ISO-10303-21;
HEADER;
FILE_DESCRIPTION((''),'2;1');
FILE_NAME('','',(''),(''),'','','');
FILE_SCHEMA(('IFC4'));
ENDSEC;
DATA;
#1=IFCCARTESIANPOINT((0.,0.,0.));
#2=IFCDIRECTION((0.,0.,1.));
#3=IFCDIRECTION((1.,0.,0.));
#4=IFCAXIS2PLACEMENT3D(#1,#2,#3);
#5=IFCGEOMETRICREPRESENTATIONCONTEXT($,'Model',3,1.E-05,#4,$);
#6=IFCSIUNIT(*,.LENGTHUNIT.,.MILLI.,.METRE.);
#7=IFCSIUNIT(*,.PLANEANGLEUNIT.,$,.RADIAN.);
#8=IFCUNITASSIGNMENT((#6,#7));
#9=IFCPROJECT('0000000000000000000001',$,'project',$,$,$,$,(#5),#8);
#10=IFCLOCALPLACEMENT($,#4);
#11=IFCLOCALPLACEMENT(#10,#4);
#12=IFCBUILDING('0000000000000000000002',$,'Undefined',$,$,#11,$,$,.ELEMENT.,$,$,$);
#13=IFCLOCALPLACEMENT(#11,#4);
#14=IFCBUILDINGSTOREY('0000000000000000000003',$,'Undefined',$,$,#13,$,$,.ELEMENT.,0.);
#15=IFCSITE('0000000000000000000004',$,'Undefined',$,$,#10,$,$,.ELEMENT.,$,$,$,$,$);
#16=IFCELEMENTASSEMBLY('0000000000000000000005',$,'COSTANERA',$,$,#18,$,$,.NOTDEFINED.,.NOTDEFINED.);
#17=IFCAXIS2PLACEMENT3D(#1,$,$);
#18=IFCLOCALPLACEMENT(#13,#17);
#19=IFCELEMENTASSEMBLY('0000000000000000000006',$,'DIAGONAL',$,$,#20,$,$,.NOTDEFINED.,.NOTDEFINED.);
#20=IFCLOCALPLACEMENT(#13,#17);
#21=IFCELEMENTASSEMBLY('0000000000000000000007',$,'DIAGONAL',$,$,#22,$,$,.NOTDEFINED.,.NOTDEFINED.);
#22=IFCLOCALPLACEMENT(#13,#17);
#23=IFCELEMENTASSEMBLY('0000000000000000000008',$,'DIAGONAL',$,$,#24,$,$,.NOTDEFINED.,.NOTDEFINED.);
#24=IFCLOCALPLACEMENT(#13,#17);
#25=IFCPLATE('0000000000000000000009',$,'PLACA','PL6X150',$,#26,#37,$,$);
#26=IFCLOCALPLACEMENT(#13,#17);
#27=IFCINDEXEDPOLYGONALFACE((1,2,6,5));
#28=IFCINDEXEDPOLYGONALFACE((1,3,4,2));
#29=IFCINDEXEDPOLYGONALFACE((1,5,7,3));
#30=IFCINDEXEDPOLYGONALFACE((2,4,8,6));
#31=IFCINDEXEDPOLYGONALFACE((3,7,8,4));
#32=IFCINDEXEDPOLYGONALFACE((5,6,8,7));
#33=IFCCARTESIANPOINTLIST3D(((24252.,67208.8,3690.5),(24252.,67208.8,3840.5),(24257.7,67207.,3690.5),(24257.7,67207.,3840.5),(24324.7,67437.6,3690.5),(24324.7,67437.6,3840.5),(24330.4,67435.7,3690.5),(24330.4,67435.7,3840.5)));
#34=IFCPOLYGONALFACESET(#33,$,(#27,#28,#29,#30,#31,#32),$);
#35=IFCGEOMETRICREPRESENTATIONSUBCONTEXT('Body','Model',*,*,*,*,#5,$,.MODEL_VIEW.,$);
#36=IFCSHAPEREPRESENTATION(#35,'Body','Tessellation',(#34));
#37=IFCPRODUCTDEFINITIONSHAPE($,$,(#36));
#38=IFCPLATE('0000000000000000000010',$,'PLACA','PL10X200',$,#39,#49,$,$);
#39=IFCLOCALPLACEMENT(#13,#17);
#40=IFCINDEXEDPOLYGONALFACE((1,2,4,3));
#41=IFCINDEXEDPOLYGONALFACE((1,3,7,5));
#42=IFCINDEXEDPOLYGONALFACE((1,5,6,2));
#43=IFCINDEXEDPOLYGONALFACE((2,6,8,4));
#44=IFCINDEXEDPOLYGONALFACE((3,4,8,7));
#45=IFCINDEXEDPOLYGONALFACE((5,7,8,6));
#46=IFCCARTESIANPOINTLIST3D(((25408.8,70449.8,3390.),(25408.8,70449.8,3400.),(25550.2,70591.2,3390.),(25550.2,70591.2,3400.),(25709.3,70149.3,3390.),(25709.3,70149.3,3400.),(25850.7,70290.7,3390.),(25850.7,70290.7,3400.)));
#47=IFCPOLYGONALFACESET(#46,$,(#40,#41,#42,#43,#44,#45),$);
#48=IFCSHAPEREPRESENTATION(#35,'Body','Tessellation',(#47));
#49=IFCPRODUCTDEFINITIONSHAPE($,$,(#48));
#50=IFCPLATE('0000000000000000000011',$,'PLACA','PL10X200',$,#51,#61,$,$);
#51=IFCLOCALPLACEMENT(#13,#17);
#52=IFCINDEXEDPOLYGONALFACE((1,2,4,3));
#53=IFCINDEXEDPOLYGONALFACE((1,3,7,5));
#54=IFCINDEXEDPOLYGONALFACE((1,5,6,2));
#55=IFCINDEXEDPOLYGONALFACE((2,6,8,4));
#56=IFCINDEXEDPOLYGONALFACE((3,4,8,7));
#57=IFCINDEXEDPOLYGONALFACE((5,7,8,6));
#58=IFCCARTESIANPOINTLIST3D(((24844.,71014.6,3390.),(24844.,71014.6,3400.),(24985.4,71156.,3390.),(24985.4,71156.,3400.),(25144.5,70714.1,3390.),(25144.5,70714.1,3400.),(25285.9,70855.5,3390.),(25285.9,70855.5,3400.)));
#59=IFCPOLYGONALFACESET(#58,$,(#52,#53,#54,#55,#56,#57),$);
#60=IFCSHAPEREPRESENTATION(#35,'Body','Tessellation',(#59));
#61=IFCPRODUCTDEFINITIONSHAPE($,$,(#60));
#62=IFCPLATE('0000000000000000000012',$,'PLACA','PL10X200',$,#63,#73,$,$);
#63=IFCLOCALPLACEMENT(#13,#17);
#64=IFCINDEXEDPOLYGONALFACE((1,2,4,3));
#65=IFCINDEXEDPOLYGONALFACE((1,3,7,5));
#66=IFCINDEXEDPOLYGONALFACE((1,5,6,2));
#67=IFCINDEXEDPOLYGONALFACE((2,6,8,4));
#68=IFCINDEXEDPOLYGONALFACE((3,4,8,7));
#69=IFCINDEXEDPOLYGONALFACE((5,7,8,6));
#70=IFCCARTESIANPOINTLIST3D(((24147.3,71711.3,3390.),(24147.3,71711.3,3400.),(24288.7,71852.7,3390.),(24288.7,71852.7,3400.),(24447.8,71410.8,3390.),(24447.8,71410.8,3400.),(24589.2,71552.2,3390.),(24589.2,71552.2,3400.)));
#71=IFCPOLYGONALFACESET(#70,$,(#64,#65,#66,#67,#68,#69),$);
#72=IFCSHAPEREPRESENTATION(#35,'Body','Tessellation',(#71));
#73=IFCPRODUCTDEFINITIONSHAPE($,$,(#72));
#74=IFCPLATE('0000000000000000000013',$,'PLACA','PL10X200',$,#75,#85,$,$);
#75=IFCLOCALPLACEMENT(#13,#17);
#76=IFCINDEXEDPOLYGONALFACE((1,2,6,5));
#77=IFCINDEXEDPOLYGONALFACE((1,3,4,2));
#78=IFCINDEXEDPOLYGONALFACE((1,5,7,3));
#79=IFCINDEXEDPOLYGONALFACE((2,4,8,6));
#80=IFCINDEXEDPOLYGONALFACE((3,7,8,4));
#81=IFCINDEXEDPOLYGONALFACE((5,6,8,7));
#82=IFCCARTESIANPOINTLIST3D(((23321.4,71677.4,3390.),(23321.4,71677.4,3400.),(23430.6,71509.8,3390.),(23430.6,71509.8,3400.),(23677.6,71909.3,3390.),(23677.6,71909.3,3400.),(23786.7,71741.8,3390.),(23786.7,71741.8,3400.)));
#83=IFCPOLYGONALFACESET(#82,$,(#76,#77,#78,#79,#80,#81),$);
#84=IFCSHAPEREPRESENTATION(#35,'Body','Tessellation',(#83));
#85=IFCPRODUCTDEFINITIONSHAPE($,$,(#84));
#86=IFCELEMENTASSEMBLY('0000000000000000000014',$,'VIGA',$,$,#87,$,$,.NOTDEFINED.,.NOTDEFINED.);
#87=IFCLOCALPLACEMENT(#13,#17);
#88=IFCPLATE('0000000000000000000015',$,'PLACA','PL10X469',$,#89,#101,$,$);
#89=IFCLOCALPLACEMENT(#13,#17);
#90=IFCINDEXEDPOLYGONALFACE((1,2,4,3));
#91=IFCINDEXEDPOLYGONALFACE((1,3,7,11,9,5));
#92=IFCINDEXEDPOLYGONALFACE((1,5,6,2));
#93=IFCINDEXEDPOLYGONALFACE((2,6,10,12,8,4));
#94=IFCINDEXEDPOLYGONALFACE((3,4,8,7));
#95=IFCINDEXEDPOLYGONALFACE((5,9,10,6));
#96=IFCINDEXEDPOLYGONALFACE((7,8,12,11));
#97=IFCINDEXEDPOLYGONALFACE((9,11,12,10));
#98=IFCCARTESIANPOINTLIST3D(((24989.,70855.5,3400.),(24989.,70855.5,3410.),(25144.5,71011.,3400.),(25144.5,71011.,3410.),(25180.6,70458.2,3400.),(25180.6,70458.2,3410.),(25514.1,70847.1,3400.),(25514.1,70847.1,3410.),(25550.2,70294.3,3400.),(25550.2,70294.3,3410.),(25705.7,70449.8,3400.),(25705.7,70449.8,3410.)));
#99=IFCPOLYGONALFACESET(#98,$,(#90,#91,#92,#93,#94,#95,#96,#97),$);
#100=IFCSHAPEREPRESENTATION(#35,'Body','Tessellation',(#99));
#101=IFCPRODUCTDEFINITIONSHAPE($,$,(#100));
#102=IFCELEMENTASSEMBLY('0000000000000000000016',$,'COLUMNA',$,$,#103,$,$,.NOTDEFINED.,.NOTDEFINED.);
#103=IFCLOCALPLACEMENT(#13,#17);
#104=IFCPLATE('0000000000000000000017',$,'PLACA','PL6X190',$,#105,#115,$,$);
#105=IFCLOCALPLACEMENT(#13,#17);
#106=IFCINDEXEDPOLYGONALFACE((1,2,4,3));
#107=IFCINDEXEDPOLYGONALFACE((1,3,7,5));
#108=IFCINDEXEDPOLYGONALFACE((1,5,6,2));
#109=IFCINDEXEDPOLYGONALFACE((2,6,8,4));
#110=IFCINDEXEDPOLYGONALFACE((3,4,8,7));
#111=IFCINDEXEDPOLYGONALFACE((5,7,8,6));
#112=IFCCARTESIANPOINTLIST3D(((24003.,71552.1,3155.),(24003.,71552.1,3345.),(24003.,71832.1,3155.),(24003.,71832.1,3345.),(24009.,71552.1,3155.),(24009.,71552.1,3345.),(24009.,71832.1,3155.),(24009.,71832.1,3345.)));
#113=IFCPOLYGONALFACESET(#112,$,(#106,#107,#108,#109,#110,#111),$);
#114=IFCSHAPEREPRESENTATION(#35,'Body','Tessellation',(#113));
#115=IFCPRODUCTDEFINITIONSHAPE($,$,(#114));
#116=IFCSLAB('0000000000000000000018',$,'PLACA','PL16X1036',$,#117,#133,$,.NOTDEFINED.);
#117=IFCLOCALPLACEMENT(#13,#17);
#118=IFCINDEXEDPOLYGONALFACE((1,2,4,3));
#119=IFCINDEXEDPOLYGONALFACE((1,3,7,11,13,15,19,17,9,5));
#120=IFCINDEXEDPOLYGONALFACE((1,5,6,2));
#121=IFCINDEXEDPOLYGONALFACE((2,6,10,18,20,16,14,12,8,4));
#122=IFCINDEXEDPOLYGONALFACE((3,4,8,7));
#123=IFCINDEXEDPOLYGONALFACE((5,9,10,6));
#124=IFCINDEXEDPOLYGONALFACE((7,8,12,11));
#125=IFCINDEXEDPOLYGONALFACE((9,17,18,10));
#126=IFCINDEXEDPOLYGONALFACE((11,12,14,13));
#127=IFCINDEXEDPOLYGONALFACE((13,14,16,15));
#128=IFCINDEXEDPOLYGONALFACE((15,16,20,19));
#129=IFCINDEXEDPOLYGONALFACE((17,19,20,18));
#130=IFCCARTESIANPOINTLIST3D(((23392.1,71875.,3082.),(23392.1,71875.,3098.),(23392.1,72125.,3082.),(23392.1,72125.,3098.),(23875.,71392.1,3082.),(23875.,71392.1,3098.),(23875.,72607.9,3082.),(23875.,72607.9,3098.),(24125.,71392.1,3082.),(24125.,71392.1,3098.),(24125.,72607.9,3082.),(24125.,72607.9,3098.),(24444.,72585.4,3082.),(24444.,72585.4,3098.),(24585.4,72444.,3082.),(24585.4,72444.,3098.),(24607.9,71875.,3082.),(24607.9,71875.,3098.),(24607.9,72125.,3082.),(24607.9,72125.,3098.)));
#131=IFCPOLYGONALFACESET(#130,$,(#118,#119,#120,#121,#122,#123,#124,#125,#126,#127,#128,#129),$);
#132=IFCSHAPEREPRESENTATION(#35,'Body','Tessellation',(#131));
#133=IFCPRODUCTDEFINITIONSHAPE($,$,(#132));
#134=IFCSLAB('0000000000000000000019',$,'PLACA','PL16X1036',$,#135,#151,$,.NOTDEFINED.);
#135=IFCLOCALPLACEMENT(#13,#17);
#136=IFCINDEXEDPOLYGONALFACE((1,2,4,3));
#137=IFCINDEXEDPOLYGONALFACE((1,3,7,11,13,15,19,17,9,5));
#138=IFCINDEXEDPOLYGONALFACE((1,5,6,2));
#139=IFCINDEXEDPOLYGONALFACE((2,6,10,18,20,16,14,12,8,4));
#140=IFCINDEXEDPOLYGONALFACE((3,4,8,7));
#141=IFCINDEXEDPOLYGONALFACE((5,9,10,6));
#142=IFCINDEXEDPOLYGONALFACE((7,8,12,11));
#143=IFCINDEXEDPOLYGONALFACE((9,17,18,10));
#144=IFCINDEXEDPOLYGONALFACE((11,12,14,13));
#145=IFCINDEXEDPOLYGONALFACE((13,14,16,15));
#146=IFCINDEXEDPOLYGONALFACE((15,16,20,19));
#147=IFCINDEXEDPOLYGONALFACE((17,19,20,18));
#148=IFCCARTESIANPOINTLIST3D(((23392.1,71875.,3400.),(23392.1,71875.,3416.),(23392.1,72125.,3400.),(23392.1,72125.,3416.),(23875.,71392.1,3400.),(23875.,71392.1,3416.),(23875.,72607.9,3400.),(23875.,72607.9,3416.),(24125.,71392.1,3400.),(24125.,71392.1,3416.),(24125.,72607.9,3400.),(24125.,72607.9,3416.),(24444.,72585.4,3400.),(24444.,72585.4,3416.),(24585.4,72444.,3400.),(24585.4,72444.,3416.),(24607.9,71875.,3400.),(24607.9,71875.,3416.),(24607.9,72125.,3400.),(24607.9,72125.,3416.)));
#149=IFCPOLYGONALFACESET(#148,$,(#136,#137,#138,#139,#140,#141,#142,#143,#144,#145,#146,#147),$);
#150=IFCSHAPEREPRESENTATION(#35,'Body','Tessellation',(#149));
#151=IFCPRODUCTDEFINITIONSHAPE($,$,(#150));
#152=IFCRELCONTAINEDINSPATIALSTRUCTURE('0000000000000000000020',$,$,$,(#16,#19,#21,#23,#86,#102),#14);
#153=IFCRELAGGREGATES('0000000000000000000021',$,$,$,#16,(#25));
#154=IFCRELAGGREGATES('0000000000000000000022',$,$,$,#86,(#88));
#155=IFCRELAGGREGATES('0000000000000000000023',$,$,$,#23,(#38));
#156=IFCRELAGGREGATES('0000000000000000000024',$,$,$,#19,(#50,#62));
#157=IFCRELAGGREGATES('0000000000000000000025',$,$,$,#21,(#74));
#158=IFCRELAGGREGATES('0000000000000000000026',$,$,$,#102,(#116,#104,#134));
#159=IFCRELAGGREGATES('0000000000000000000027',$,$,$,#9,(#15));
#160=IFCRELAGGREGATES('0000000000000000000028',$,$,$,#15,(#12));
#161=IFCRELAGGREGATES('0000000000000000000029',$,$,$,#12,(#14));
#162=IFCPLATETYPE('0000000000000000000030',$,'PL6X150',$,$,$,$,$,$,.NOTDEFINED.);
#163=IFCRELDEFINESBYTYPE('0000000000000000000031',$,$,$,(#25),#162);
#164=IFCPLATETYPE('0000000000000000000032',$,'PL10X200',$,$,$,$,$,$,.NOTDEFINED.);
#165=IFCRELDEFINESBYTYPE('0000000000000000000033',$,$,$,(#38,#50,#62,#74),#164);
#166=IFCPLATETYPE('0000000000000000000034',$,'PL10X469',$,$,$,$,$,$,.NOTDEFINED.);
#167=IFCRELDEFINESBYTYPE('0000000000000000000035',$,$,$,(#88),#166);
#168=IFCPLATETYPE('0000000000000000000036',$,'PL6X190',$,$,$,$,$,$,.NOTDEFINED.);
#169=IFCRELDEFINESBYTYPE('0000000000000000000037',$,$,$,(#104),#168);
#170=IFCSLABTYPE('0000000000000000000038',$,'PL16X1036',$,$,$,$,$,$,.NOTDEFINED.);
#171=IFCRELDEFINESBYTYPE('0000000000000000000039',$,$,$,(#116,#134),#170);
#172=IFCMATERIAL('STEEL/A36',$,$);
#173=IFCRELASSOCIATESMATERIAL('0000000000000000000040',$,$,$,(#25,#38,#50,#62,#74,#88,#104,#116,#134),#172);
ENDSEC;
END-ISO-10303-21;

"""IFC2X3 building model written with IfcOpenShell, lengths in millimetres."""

from ifc_helpers import new_model, si_unit, frame, origin_with_axes, place, context, subcontext, project, spatial, polyline, outline, extrude, material, type_object, element, aggregate, save


model = new_model("IFC2X3")

# Units and contexts
model_context = context("Model", 3, precision=1e-05, world=origin_with_axes())
body_context = subcontext(model_context, "Body", "Model", "MODEL_VIEW")
ifc_project = project(units=[si_unit("LENGTHUNIT", "METRE", prefix="MILLI"), si_unit("PLANEANGLEUNIT", "RADIAN")], contexts=[model_context])

# Site, building, storey
site_placement = place(None, origin_with_axes())
site = spatial("IfcSite", under=ifc_project, at=site_placement, Name="Undefined", CompositionType="ELEMENT")
building_placement = place(site_placement, origin_with_axes())
building = spatial("IfcBuilding", under=site, at=building_placement, Name="Undefined", CompositionType="ELEMENT")
storey_placement = place(building_placement, origin_with_axes())
storey = spatial("IfcBuildingStorey", under=building, at=storey_placement, Name="Undefined", CompositionType="ELEMENT", Elevation=0.0)

# Element assemblies
assembly_1_placement = place(storey_placement, origin_with_axes())
assembly_1 = element("IfcElementAssembly", 1, at=assembly_1_placement, inside=storey, Name="COSTANERA", AssemblyPlace="NOTDEFINED", PredefinedType="NOTDEFINED")
ifc_material_1 = material(Name="STEEL/A36")
assembly_2_placement = place(storey_placement, origin_with_axes())
assembly_2 = element("IfcElementAssembly", 2, at=assembly_2_placement, inside=storey, Name="DIAGONAL", AssemblyPlace="NOTDEFINED", PredefinedType="NOTDEFINED")

# Element assemblies
assembly_3_placement = place(storey_placement, origin_with_axes())
assembly_3 = element("IfcElementAssembly", 3, at=assembly_3_placement, inside=storey, Name="DIAGONAL", AssemblyPlace="NOTDEFINED", PredefinedType="NOTDEFINED")
assembly_4_placement = place(storey_placement, origin_with_axes())
assembly_4 = element("IfcElementAssembly", 4, at=assembly_4_placement, inside=storey, Name="DIAGONAL", AssemblyPlace="NOTDEFINED", PredefinedType="NOTDEFINED")

# Shared definitions
plate_type_1 = type_object("IfcPlateType", Name="PL6X150", PredefinedType="NOTDEFINED")

# Plates
plate_1_placement = place(assembly_1_placement, frame((24254.8, 67207.9, 3765.5), z_axis=(0.952956, -0.30311, 0.0), x_axis=(0.30311, 0.952956, 0.0)))
plate_1 = element("IfcPlate", 5, at=plate_1_placement, type_object=plate_type_1, material=ifc_material_1, Name="PLACA", Description="PL6X150", context=body_context, shape_type="SweptSolid", body=[
    extrude(outline(polyline([(0.0, -75.0), (0.0, 75.0), (240.0, 75.0), (240.0, -75.0), (0.0, -75.0)])), frame((0.0, 0.0, -3.0), z_axis=(0.0, 0.0, 1.0), x_axis=(1.0, 0.0, 0.0)), (0.0, 0.0, 1.0), 6.0),
])
aggregate(assembly_1, [plate_1])
plate_type_2 = type_object("IfcPlateType", Name="PL10X200", PredefinedType="NOTDEFINED")
plate_2_placement = place(assembly_4_placement, frame((25479.5, 70520.5, 3395.0), z_axis=(0.0, 0.0, 1.0), x_axis=(0.707107, -0.707107, 0.0)))
plate_2 = element("IfcPlate", 6, at=plate_2_placement, type_object=plate_type_2, material=ifc_material_1, Name="PLACA", Description="PL10X200", context=body_context, shape_type="SweptSolid", body=[
    extrude(outline(polyline([(0.0, -100.0), (0.0, 100.0), (425.0, 100.0), (425.0, -100.0), (0.0, -100.0)])), frame((0.0, 0.0, -5.0), z_axis=(0.0, 0.0, 1.0), x_axis=(1.0, 0.0, 0.0)), (0.0, 0.0, 1.0), 10.0),
])
plate_3_placement = place(assembly_2_placement, frame((25215.2, 70784.8, 3395.0), z_axis=(0.0, 0.0, 1.0), x_axis=(-0.707107, 0.707107, 0.0)))
plate_3 = element("IfcPlate", 7, at=plate_3_placement, type_object=plate_type_2, material=ifc_material_1, Name="PLACA", Description="PL10X200", context=body_context, shape_type="SweptSolid", body=[
    extrude(outline(polyline([(0.0, -100.0), (0.0, 100.0), (425.0, 100.0), (425.0, -100.0), (0.0, -100.0)])), frame((0.0, 0.0, -5.0), z_axis=(0.0, 0.0, 1.0), x_axis=(1.0, 0.0, 0.0)), (0.0, 0.0, 1.0), 10.0),
])
plate_4_placement = place(assembly_2_placement, frame((24218.0, 71782.0, 3395.0), z_axis=(0.0, 0.0, -1.0), x_axis=(0.707107, -0.707107, 0.0)))
plate_4 = element("IfcPlate", 8, at=plate_4_placement, type_object=plate_type_2, material=ifc_material_1, Name="PLACA", Description="PL10X200", context=body_context, shape_type="SweptSolid", body=[
    extrude(outline(polyline([(0.0, -100.0), (0.0, 100.0), (425.0, 100.0), (425.0, -100.0), (0.0, -100.0)])), frame((0.0, 0.0, -5.0), z_axis=(0.0, 0.0, 1.0), x_axis=(1.0, 0.0, 0.0)), (0.0, 0.0, 1.0), 10.0),
])
plate_5_placement = place(assembly_3_placement, frame((23732.1, 71825.5, 3395.0), z_axis=(0.0, 0.0, -1.0), x_axis=(-0.837977, -0.545706, 0.0)))
plate_5 = element("IfcPlate", 9, at=plate_5_placement, type_object=plate_type_2, material=ifc_material_1, Name="PLACA", Description="PL10X200", context=body_context, shape_type="SweptSolid", body=[
    extrude(outline(polyline([(0.0, -100.0), (0.0, 100.0), (425.0, 100.0), (425.0, -100.0), (0.0, -100.0)])), frame((0.0, 0.0, -5.0), z_axis=(0.0, 0.0, 1.0), x_axis=(1.0, 0.0, 0.0)), (0.0, 0.0, 1.0), 10.0),
])

# Element assembly, plate
assembly_5_placement = place(storey_placement, origin_with_axes())
assembly_5 = element("IfcElementAssembly", 10, at=assembly_5_placement, inside=storey, Name="VIGA", AssemblyPlace="NOTDEFINED", PredefinedType="NOTDEFINED")
plate_type_3 = type_object("IfcPlateType", Name="PL10X469", PredefinedType="NOTDEFINED")
plate_6_placement = place(assembly_5_placement, frame((25180.6, 70458.2, 3405.0), z_axis=(0.0, 0.0, -1.0), x_axis=(-0.434461, 0.900691, 0.0)))
plate_6 = element("IfcPlate", 11, at=plate_6_placement, type_object=plate_type_3, material=ifc_material_1, Name="PLACA", Description="PL10X469", context=body_context, shape_type="SweptSolid", body=[
    extrude(outline(polyline([(0.0, 0.0), (441.0, 0.0), (513.6, 207.7), (205.3, 469.4), (-235.7, 469.4), (-308.3, 261.7), (0.0, 0.0)])), frame((0.0, 0.0, -5.0), z_axis=(0.0, 0.0, 1.0), x_axis=(1.0, 0.0, 0.0)), (0.0, 0.0, 1.0), 10.0),
])
aggregate(assembly_5, [plate_6])

# Element assembly, plate, slabs
assembly_6_placement = place(storey_placement, origin_with_axes())
assembly_6 = element("IfcElementAssembly", 12, at=assembly_6_placement, inside=storey, Name="COLUMNA", AssemblyPlace="NOTDEFINED", PredefinedType="NOTDEFINED")
plate_type_4 = type_object("IfcPlateType", Name="PL6X190", PredefinedType="NOTDEFINED")
plate_7_placement = place(assembly_6_placement, frame((24006.0, 71552.1, 3250.0), z_axis=(1.0, 0.0, 0.0), x_axis=(0.0, 1.0, 0.0)))
plate_7 = element("IfcPlate", 13, at=plate_7_placement, type_object=plate_type_4, material=ifc_material_1, Name="PLACA", Description="PL6X190", context=body_context, shape_type="SweptSolid", body=[
    extrude(outline(polyline([(0.0, -95.0), (0.0, 95.0), (280.0, 95.0), (280.0, -95.0), (0.0, -95.0)])), frame((0.0, 0.0, -3.0), z_axis=(0.0, 0.0, 1.0), x_axis=(1.0, 0.0, 0.0)), (0.0, 0.0, 1.0), 6.0),
])
slab_type = type_object("IfcSlabType", Name="PL16X1036", PredefinedType="NOTDEFINED")
slab_1_placement = place(assembly_6_placement, frame((24125.0, 71392.1, 3090.0), z_axis=(0.0, 0.0, 1.0), x_axis=(0.707107, 0.707107, 0.0)))
slab_1 = element("IfcSlab", 14, at=slab_1_placement, type_object=slab_type, material=ifc_material_1, Name="PLACA", Description="PL16X1036", PredefinedType="NOTDEFINED", context=body_context, shape_type="SweptSolid", body=[
    extrude(outline(polyline([(0.0, 0.0), (682.9, 0.0), (859.7, 176.8), (1069.4, 418.2), (1069.4, 618.2), (859.7, 859.7), (682.9, 1036.5), (0.0, 1036.5), (-176.8, 859.7), (-176.8, 176.8), (0.0, 0.0)])), frame((0.0, 0.0, -8.0), z_axis=(0.0, 0.0, 1.0), x_axis=(1.0, 0.0, 0.0)), (0.0, 0.0, 1.0), 16.0),
])
slab_2_placement = place(assembly_6_placement, frame((24125.0, 71392.1, 3408.0), z_axis=(0.0, 0.0, 1.0), x_axis=(0.707107, 0.707107, 0.0)))
slab_2 = element("IfcSlab", 15, at=slab_2_placement, type_object=slab_type, material=ifc_material_1, Name="PLACA", Description="PL16X1036", PredefinedType="NOTDEFINED", context=body_context, shape_type="SweptSolid", body=[
    extrude(outline(polyline([(0.0, 0.0), (682.9, 0.0), (859.7, 176.8), (1069.4, 418.2), (1069.4, 618.2), (859.7, 859.7), (682.9, 1036.5), (0.0, 1036.5), (-176.8, 859.7), (-176.8, 176.8), (0.0, 0.0)])), frame((0.0, 0.0, -8.0), z_axis=(0.0, 0.0, 1.0), x_axis=(1.0, 0.0, 0.0)), (0.0, 0.0, 1.0), 16.0),
])

aggregate(assembly_4, [plate_2])
aggregate(assembly_2, [plate_3, plate_4])
aggregate(assembly_3, [plate_5])
aggregate(assembly_6, [slab_1, plate_7, slab_2])

save(model, "model.ifc")
